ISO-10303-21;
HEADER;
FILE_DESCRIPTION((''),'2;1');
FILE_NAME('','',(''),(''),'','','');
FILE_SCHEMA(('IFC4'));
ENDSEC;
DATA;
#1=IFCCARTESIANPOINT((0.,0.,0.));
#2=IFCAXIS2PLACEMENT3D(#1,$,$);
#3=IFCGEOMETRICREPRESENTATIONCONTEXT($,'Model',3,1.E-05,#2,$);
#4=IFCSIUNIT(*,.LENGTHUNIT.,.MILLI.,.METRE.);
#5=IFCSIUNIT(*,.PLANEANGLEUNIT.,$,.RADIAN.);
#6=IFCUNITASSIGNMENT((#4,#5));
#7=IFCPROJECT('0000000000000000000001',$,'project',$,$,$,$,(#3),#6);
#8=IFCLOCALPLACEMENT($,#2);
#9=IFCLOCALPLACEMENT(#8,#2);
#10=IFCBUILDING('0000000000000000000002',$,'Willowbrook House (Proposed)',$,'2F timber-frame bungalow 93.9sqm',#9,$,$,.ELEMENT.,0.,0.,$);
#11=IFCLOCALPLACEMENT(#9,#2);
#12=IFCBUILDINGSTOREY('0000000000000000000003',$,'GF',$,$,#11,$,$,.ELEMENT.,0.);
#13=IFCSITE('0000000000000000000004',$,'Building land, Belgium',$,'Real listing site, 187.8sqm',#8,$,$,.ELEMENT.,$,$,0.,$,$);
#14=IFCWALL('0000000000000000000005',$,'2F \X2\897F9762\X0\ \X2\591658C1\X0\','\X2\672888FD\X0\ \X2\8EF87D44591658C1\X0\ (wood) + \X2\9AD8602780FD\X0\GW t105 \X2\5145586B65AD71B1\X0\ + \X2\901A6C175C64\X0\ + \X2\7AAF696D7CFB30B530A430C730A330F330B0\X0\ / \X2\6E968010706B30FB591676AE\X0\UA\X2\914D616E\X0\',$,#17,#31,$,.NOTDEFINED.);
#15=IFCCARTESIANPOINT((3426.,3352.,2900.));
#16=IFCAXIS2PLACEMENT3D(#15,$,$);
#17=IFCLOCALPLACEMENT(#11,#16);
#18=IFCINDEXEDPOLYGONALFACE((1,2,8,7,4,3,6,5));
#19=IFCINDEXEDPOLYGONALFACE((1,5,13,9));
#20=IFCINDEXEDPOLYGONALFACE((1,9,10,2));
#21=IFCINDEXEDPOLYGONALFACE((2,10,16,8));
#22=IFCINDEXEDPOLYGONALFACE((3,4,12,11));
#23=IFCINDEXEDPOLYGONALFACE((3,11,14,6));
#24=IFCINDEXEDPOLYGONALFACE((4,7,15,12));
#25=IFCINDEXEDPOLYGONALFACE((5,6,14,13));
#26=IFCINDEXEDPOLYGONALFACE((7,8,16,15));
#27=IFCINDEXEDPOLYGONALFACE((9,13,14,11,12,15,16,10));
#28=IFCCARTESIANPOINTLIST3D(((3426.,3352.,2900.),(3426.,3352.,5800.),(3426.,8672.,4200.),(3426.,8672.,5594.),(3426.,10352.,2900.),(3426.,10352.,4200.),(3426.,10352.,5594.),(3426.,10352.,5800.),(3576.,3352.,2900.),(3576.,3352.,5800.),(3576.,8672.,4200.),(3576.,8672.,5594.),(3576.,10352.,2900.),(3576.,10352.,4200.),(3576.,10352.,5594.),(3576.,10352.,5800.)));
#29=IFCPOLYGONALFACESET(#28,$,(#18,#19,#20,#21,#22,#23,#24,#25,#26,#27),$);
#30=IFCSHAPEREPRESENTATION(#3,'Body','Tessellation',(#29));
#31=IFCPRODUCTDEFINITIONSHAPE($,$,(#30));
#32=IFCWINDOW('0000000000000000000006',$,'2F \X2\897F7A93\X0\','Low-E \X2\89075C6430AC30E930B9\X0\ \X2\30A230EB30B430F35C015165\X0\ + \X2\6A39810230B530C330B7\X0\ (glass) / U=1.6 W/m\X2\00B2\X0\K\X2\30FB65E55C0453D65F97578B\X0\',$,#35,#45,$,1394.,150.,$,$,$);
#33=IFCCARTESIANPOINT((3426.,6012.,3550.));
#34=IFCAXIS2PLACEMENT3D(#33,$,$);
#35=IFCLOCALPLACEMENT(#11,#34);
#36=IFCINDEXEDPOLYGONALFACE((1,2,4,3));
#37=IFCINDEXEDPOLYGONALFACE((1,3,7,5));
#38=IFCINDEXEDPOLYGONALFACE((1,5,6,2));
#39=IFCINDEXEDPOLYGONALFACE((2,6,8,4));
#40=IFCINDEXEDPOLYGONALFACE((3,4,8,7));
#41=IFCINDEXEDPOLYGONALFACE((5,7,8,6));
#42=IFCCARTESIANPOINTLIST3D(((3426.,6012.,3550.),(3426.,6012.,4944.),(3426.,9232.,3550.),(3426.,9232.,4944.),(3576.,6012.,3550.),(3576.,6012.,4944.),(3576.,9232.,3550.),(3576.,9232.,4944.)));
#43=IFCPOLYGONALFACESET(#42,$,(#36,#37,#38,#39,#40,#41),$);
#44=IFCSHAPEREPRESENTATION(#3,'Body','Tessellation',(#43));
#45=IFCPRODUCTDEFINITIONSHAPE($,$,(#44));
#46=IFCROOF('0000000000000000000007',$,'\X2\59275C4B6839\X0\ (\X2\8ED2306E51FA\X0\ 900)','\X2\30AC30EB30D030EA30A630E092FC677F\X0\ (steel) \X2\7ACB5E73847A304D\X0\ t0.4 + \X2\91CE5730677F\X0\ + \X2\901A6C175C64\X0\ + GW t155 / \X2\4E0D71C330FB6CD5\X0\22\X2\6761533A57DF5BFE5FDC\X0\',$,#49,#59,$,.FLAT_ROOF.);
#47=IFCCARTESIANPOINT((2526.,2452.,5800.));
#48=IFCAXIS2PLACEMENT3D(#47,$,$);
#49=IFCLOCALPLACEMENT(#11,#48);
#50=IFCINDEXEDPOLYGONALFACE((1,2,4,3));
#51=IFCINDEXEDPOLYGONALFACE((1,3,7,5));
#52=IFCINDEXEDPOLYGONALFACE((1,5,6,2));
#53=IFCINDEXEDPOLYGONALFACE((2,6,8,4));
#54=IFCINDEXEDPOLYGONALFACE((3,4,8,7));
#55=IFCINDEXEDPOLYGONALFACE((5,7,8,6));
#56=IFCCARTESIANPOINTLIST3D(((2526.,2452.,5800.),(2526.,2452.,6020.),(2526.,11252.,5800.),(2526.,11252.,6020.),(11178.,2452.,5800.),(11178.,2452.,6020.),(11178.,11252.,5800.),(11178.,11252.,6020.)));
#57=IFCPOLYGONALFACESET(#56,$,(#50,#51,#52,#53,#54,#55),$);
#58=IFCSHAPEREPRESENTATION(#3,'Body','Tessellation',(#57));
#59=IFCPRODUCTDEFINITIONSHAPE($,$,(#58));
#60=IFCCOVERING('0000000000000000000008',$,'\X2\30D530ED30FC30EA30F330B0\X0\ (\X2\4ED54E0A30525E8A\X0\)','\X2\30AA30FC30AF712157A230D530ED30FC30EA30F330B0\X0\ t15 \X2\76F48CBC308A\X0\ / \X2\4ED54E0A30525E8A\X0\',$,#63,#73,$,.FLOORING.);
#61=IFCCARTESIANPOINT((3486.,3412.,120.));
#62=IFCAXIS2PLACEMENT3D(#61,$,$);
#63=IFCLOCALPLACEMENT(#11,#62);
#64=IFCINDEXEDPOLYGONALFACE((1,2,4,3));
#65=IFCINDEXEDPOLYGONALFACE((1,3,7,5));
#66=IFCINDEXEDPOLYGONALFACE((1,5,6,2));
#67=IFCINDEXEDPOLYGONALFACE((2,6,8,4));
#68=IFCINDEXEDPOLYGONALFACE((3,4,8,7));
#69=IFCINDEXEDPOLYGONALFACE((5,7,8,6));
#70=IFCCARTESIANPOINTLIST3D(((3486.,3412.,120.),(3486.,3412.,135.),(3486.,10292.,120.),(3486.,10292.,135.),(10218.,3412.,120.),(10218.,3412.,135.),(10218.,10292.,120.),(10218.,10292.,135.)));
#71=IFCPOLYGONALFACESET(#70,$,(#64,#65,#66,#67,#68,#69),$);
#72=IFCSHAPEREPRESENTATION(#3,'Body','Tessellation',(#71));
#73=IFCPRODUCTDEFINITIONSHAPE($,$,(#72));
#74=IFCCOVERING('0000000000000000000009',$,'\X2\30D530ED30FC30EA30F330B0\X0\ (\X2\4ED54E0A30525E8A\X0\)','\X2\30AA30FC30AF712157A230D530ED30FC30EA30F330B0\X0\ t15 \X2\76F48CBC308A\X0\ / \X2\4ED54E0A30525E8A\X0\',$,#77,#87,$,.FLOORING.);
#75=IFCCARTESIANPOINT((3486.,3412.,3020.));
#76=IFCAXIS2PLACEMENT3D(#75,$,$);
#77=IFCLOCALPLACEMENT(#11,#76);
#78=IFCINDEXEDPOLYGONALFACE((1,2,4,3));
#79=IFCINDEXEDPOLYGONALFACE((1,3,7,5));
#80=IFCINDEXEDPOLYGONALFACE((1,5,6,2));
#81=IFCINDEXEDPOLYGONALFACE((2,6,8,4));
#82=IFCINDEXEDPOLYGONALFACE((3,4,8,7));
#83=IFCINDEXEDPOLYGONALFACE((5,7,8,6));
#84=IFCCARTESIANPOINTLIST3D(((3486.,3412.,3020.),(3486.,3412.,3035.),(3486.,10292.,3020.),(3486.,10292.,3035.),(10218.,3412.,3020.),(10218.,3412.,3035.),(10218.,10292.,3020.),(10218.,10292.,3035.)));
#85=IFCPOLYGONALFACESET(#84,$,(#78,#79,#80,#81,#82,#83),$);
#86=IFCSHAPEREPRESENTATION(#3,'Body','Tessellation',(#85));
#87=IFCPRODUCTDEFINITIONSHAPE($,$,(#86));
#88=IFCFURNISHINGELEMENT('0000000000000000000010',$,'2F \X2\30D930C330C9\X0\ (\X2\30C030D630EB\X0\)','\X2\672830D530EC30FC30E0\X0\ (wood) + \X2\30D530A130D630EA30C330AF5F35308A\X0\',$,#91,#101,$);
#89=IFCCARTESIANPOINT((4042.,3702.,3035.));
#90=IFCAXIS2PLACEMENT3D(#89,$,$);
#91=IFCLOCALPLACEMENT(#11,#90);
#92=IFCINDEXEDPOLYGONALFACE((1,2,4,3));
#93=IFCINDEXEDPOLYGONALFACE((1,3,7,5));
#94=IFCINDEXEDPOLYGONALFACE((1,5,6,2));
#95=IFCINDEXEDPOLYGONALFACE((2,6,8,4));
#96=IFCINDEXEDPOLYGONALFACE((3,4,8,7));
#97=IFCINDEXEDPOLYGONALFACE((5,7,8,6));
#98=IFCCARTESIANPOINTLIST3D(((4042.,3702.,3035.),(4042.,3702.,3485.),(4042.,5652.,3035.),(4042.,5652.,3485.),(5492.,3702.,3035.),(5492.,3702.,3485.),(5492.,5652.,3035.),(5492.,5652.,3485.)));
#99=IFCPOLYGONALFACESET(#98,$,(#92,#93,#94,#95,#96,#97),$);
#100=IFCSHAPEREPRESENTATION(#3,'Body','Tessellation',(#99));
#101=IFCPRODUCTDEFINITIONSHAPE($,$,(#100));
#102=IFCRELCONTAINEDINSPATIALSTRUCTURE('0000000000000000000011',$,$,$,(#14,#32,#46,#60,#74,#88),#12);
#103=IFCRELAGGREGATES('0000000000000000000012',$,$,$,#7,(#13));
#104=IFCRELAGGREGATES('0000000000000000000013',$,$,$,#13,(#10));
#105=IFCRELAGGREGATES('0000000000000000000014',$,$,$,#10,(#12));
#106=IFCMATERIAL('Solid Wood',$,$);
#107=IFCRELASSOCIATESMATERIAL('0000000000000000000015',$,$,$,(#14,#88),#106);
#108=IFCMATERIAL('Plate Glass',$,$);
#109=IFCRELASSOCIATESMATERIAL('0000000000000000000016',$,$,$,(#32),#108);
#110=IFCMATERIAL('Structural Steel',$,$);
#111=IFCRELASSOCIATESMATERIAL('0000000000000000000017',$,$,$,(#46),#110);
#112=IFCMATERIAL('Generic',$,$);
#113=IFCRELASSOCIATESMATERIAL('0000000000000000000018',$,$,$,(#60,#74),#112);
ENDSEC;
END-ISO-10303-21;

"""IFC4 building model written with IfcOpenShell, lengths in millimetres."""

from ifc_helpers import new_model, si_unit, frame, frame_2d, origin, place, context, project, spatial, rectangle, extrude, material, element, fill, save


model = new_model("IFC4")

# Units and contexts
model_context = context("Model", 3, precision=1e-05, world=origin())
ifc_project = project(units=[si_unit("LENGTHUNIT", "METRE", prefix="MILLI"), si_unit("PLANEANGLEUNIT", "RADIAN")], contexts=[model_context])

# Site, building, storey
site_placement = place(None, origin())
site = spatial("IfcSite", under=ifc_project, at=site_placement, Name="Building land, Belgium", ObjectType="Real listing site, 187.8sqm", CompositionType="ELEMENT", RefElevation=0.0)
building_placement = place(site_placement, origin())
building = spatial("IfcBuilding", under=site, at=building_placement, Name="Willowbrook House (Proposed)", ObjectType="2F timber-frame bungalow 93.9sqm", CompositionType="ELEMENT", ElevationOfRefHeight=0.0, ElevationOfTerrain=0.0)
storey_placement = place(building_placement, origin())
storey = spatial("IfcBuildingStorey", under=building, at=storey_placement, Name="GF", CompositionType="ELEMENT", Elevation=0.0)

# Shared definitions
ifc_material_1 = material(Name="Solid Wood")

# Shared definitions
ifc_material_2 = material(Name="Plate Glass")

# Wall, opening, window
wall_1_placement = place(storey_placement, frame((3426.0, 3352.0, 2900.0)))
wall_1 = element("IfcWall", 1, at=wall_1_placement, inside=storey, material=ifc_material_1, Name="2F 西面 外壁", Description="木製 軸組外壁 (wood) + 高性能GW t105 充填断熱 + 通気層 + 窯業系サイディング / 準耐火・外皮UA配慮", PredefinedType="NOTDEFINED", context=model_context, shape_type="SweptSolid", body=[
    extrude(rectangle(XDim=150.0, YDim=7000.0, at=frame_2d((75.0, 3500.0))), frame((3426.0, 3352.0, 2900.0)), (0.0, 0.0, 1.0), 2900.0),
])
opening_1_placement = place(storey_placement, frame((3426.0, 6012.0, 3550.0)))
opening_1 = element("IfcOpeningElement", 2, at=opening_1_placement, cuts=wall_1, PredefinedType="NOTDEFINED", context=model_context, shape_type="SweptSolid", body=[
    extrude(rectangle(XDim=150.0, YDim=3220.0, at=frame_2d((75.0, 1610.0))), frame((3426.0, 6012.0, 3550.0)), (0.0, 0.0, 1.0), 1394.0),
])
window_1_placement = place(storey_placement, frame((3426.0, 6012.0, 3550.0)))
window_1 = element("IfcWindow", 3, at=window_1_placement, inside=storey, material=ifc_material_2, Name="2F 西窓", Description="Low-E 複層ガラス アルゴン封入 + 樹脂サッシ (glass) / U=1.6 W/m²K・日射取得型", OverallHeight=1394.0, OverallWidth=150.0, context=model_context, shape_type="SweptSolid", body=[
    extrude(rectangle(XDim=150.0, YDim=3220.0, at=frame_2d((75.0, 1610.0))), frame((3426.0, 6012.0, 3550.0)), (0.0, 0.0, 1.0), 1394.0),
])
fill(opening_1, window_1)

# Roof
ifc_material_3 = material(Name="Structural Steel")
roof_placement = place(storey_placement, frame((2526.0, 2452.0, 5800.0)))
element("IfcRoof", 4, at=roof_placement, inside=storey, material=ifc_material_3, Name="大屋根 (軒の出 900)", Description="ガルバリウム鋼板 (steel) 立平葺き t0.4 + 野地板 + 通気層 + GW t155 / 不燃・法22条区域対応", PredefinedType="FLAT_ROOF", context=model_context, shape_type="SweptSolid", body=[
    extrude(rectangle(XDim=8652.0, YDim=8800.0, at=frame_2d((4326.0, 4400.0))), frame((2526.0, 2452.0, 5800.0)), (0.0, 0.0, 1.0), 220.0),
])

# Coverings
ifc_material_4 = material(Name="Generic")
covering_1_placement = place(storey_placement, frame((3486.0, 3412.0, 120.0)))
element("IfcCovering", 5, at=covering_1_placement, inside=storey, material=ifc_material_4, Name="フローリング (仕上げ床)", Description="オーク無垢フローリング t15 直貼り / 仕上げ床", PredefinedType="FLOORING", context=model_context, shape_type="SweptSolid", body=[
    extrude(rectangle(XDim=6732.0, YDim=6880.0, at=frame_2d((3366.0, 3440.0))), frame((3486.0, 3412.0, 120.0)), (0.0, 0.0, 1.0), 15.0),
])
covering_2_placement = place(storey_placement, frame((3486.0, 3412.0, 3020.0)))
element("IfcCovering", 6, at=covering_2_placement, inside=storey, material=ifc_material_4, Name="フローリング (仕上げ床)", Description="オーク無垢フローリング t15 直貼り / 仕上げ床", PredefinedType="FLOORING", context=model_context, shape_type="SweptSolid", body=[
    extrude(rectangle(XDim=6732.0, YDim=6880.0, at=frame_2d((3366.0, 3440.0))), frame((3486.0, 3412.0, 3020.0)), (0.0, 0.0, 1.0), 15.0),
])

# Furnishing element
furnishing_placement = place(storey_placement, frame((4042.0, 3702.0, 3035.0)))
element("IfcFurnishingElement", 7, at=furnishing_placement, inside=storey, material=ifc_material_1, Name="2F ベッド (ダブル)", Description="木フレーム (wood) + ファブリック張り", context=model_context, shape_type="SweptSolid", body=[
    extrude(rectangle(XDim=1450.0, YDim=1950.0, at=frame_2d((725.0, 975.0))), frame((4042.0, 3702.0, 3035.0)), (0.0, 0.0, 1.0), 450.0),
])

save(model, "model.ifc")
